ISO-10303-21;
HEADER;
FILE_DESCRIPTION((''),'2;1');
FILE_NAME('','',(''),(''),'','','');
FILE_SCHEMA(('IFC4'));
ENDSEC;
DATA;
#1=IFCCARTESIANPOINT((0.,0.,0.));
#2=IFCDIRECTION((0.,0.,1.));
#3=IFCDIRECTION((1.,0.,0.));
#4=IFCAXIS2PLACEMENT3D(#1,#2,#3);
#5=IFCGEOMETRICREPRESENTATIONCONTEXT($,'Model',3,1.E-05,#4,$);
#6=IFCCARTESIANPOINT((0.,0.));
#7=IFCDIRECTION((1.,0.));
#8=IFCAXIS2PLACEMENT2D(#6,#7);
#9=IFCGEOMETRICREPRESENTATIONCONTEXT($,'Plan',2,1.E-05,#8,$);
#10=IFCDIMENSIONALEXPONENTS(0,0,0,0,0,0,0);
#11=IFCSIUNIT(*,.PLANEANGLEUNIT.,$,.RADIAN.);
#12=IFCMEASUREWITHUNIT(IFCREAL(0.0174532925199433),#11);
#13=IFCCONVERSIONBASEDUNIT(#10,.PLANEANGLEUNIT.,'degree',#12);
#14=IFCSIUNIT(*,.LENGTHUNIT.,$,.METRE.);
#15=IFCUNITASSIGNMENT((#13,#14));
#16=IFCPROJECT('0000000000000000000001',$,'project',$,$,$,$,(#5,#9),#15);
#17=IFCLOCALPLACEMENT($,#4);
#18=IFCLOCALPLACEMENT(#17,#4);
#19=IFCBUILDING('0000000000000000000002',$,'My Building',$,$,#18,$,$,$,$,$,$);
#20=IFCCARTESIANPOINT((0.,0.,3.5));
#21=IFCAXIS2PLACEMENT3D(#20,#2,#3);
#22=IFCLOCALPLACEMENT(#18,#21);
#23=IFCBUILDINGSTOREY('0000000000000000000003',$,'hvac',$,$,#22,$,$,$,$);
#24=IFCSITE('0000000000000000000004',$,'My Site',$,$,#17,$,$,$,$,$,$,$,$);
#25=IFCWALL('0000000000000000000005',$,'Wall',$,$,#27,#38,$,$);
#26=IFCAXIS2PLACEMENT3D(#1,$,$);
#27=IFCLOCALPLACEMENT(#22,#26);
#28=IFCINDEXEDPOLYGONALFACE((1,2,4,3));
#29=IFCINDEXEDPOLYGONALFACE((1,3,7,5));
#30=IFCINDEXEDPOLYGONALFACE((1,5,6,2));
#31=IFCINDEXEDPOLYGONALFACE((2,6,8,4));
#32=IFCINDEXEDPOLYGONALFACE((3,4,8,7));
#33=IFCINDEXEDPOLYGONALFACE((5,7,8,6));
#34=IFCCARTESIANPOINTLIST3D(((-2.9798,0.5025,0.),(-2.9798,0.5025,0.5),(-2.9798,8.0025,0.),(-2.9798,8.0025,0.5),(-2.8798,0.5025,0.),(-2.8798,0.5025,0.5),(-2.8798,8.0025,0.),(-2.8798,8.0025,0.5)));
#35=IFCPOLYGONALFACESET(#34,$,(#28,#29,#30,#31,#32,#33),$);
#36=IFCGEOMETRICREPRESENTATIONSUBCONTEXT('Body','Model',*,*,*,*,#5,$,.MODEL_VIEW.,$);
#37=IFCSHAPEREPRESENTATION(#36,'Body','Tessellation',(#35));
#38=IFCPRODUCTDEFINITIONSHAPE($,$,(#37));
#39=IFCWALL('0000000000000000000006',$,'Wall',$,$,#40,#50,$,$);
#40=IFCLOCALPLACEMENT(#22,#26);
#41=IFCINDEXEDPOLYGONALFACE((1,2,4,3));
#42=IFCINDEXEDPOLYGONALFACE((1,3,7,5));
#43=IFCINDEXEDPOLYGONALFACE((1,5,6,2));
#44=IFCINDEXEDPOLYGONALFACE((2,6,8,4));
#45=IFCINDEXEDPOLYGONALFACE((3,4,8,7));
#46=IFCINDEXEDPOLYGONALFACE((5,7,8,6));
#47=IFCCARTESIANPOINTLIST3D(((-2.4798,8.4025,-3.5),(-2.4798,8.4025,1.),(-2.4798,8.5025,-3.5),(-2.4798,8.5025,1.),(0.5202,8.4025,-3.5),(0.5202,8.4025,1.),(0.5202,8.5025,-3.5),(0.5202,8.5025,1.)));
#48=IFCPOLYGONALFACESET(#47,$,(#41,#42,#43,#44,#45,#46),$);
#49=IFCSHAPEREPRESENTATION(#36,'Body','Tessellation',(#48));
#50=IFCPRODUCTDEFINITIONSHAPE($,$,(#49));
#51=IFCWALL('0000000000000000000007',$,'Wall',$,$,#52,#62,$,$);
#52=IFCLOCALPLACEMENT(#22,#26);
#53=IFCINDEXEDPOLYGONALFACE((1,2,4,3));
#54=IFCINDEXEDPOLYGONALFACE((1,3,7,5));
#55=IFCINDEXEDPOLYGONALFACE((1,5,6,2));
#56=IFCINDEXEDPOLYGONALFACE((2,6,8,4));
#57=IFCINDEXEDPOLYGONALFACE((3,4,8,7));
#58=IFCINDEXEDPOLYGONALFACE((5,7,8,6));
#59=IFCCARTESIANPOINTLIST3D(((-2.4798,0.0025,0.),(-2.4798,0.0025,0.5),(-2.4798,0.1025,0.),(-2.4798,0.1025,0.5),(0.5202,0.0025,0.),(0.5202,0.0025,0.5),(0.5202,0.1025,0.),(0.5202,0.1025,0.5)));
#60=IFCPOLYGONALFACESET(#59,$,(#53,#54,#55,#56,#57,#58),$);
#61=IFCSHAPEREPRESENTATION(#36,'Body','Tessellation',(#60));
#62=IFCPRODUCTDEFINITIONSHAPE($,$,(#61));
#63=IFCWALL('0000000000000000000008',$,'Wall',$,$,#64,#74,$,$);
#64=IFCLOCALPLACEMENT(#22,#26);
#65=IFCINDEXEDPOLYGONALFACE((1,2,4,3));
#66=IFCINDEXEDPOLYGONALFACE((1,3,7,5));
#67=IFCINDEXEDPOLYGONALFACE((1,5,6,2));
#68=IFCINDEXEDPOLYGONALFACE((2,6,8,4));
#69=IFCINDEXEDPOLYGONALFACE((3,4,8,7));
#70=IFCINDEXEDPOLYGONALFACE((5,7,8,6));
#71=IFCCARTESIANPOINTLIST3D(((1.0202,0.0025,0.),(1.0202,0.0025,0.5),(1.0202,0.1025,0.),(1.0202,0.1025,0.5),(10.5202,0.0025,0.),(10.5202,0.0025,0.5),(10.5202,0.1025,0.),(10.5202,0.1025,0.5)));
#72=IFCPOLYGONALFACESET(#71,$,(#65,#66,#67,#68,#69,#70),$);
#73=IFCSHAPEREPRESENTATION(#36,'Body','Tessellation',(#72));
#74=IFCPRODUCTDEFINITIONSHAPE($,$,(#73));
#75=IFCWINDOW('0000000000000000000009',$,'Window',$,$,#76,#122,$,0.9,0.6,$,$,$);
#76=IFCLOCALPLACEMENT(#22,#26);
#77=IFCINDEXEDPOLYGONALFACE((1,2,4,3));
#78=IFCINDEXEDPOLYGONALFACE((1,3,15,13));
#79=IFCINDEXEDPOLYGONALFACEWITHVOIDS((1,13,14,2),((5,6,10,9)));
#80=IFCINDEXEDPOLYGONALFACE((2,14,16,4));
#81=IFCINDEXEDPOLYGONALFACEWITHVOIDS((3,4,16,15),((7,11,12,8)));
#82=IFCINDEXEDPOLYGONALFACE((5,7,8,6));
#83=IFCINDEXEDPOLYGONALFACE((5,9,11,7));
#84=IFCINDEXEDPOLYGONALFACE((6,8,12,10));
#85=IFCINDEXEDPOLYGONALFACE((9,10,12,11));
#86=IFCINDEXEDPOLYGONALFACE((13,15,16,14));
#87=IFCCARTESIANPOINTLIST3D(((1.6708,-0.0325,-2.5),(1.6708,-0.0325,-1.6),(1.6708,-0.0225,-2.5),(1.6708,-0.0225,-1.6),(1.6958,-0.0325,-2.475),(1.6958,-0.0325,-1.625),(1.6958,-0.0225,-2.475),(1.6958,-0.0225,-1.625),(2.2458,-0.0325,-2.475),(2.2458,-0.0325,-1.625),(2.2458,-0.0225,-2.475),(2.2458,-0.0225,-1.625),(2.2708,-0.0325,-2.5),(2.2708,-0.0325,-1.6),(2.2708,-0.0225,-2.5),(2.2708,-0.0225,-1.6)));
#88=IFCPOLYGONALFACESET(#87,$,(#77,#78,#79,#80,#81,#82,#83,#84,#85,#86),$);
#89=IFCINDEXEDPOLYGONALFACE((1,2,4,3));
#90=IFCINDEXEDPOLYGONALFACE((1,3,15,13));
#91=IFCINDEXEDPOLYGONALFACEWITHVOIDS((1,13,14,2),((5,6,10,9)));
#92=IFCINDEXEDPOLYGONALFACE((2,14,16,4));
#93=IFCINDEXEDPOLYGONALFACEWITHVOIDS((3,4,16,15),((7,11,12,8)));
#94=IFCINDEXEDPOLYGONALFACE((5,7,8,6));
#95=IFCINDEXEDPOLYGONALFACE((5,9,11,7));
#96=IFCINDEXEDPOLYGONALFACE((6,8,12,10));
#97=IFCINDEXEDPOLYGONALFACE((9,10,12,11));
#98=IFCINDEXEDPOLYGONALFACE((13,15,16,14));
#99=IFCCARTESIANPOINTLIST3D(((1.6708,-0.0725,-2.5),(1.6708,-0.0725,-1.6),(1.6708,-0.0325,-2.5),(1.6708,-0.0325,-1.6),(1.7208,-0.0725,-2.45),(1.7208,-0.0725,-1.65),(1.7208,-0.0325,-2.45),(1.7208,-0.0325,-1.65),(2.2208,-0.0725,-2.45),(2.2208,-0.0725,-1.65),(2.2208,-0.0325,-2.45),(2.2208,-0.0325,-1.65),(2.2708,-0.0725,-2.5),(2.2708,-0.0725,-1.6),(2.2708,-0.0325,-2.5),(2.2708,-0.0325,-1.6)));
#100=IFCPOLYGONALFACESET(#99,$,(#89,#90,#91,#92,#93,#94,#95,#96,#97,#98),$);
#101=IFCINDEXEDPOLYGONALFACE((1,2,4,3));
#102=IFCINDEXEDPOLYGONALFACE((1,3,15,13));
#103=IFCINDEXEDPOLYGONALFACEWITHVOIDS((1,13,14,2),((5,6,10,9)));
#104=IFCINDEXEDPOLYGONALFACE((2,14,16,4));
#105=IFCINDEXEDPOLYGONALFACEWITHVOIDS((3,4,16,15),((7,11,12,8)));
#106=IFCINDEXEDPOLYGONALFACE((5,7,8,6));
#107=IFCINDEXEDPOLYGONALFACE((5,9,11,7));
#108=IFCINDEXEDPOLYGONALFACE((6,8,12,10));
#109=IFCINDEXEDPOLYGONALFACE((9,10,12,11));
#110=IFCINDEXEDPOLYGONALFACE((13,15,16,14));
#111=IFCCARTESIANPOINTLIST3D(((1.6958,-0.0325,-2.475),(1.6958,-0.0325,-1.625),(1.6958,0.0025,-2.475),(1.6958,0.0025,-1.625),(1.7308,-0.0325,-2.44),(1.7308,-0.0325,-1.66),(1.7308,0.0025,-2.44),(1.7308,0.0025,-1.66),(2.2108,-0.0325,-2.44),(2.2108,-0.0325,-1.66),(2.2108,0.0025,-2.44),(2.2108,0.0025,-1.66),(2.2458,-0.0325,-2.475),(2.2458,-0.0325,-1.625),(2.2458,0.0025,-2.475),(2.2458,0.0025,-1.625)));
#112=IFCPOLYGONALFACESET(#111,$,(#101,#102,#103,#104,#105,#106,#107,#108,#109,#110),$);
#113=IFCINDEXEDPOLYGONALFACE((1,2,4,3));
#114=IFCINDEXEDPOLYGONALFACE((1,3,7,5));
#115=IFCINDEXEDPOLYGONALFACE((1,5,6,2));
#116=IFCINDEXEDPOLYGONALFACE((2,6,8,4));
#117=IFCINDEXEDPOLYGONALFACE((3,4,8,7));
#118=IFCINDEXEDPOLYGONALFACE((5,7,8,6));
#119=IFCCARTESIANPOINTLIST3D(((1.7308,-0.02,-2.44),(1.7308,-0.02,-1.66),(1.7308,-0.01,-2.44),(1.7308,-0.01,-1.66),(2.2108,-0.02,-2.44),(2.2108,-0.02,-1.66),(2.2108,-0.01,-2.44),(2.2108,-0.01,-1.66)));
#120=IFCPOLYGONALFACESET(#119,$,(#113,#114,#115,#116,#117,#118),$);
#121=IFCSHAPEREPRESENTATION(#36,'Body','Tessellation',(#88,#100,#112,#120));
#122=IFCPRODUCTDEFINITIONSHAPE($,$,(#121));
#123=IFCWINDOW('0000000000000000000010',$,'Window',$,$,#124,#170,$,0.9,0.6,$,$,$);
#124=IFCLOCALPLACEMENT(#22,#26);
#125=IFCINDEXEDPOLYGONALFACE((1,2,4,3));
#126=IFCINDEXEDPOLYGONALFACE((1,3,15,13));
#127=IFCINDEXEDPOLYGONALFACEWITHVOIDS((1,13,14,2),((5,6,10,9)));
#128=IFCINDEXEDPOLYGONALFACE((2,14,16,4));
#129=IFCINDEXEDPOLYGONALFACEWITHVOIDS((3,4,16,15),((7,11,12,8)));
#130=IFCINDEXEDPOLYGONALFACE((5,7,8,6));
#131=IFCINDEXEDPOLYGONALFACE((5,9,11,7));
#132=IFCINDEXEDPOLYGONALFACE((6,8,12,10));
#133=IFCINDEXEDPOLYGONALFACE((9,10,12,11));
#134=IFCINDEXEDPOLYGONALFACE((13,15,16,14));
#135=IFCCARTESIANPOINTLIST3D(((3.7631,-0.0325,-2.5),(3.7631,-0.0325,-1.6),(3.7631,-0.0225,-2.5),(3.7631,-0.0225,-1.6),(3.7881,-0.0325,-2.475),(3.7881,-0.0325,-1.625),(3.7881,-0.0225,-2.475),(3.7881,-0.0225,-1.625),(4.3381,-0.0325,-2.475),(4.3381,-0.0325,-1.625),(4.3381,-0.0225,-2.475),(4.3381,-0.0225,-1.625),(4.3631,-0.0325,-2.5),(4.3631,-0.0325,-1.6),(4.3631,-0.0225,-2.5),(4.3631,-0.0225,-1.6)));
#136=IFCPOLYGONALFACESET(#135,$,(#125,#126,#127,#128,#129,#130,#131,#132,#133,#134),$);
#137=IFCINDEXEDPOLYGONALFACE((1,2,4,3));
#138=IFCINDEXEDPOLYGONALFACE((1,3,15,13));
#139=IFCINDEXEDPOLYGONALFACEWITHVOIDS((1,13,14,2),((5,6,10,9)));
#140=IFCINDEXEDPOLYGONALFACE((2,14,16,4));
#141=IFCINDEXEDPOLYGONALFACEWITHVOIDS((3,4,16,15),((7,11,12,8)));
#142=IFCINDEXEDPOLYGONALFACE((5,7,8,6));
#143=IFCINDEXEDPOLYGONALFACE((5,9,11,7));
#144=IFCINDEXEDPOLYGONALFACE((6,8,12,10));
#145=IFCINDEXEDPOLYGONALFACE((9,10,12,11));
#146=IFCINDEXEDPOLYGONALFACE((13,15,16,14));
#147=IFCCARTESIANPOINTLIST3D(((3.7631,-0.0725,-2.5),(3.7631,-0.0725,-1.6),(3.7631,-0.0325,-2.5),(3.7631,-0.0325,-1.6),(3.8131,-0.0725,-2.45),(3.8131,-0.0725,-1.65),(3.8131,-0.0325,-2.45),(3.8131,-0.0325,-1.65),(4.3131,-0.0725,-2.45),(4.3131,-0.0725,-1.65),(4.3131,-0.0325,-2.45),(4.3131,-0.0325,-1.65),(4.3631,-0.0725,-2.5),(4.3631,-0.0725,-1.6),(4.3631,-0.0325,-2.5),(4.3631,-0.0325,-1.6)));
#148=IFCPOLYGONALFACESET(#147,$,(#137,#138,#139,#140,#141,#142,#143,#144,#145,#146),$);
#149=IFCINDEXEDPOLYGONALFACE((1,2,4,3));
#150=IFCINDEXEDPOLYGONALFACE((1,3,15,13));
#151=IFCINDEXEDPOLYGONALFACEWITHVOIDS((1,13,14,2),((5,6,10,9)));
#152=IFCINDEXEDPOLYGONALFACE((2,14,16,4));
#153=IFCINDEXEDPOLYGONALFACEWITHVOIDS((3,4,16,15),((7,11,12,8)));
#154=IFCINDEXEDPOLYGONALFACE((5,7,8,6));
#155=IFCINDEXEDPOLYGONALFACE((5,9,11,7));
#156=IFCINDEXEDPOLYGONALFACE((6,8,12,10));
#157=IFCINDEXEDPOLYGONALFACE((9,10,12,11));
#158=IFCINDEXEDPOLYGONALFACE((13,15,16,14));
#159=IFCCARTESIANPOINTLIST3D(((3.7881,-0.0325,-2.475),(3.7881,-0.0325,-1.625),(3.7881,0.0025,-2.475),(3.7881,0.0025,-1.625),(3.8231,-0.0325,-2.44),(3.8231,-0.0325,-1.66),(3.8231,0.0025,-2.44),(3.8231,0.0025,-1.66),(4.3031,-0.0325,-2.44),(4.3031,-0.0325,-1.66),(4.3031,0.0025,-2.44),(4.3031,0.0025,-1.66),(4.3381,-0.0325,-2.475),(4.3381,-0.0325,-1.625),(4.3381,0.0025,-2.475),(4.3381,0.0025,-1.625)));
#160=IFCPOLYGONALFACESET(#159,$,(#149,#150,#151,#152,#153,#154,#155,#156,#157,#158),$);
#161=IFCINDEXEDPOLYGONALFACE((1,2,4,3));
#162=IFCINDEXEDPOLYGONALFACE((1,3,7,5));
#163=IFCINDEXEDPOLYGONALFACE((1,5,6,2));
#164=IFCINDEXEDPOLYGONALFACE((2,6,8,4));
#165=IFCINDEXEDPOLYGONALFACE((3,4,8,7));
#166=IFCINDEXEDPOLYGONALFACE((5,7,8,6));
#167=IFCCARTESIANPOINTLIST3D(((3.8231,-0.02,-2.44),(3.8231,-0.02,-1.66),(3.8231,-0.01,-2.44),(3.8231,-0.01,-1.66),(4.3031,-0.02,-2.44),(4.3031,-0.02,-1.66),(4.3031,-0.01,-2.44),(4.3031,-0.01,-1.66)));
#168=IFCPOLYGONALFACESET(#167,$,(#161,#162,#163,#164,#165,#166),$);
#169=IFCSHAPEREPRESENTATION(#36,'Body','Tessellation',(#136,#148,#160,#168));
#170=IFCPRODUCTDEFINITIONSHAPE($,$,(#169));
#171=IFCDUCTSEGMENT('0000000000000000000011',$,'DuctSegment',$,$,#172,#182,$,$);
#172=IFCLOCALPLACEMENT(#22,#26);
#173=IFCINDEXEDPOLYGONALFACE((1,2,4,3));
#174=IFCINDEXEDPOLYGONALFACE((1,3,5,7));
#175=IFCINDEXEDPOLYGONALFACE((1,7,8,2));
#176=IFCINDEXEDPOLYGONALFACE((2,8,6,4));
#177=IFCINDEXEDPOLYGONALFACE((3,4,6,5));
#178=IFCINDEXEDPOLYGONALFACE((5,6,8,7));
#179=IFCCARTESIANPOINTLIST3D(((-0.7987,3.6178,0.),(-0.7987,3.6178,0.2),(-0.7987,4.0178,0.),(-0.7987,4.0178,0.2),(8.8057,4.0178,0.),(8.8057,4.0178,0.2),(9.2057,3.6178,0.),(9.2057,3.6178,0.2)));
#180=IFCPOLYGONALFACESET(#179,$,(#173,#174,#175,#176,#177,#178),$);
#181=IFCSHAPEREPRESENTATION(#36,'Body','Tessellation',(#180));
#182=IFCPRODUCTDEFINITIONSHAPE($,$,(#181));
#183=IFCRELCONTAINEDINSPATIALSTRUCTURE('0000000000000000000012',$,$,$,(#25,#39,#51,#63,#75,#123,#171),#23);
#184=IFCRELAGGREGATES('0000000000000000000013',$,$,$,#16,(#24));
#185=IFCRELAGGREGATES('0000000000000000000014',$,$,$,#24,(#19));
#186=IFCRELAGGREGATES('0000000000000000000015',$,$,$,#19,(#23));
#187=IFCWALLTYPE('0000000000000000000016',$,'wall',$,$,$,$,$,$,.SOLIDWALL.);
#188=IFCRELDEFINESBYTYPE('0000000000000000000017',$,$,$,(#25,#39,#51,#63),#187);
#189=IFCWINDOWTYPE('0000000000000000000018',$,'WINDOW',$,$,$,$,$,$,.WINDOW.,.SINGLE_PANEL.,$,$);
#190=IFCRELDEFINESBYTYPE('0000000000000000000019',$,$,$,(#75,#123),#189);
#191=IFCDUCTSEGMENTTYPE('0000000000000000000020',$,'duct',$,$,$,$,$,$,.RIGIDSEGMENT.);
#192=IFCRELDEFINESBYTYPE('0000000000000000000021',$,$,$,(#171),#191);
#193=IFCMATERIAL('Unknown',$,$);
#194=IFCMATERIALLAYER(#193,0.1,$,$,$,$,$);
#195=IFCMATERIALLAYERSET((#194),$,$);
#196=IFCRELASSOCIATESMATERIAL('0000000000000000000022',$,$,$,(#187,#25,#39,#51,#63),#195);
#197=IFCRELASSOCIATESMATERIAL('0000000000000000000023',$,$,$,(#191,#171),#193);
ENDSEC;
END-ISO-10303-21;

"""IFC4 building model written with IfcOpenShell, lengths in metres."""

from ifc_helpers import new_model, entity, si_unit, converted_unit, frame, origin_with_axes, origin_2d_with_axis, place, context, subcontext, project, spatial, line, indexed_curve, rectangle, outline, extrude, clip, halfspace, shape, source, transform, mapped, material, layer, layer_set, layer_usage, material_profile, profile_set, profile_usage, type_object, type_shapes, element, save


model = new_model("IFC4")

# Units and contexts
model_context = context("Model", 3, precision=1e-05, world=origin_with_axes())
plan_context = context("Plan", 2, precision=1e-05, world=origin_2d_with_axis())
body_context_1 = subcontext(model_context, "Body", "Model", "MODEL_VIEW")
body_context_2 = subcontext(plan_context, "Body", "Plan", "PLAN_VIEW")
ifc_project = project(units=[converted_unit("PLANEANGLEUNIT", "degree", entity("IfcReal", 0.0174532925199433), si_unit("PLANEANGLEUNIT", "RADIAN"), dimensions=[0, 0, 0, 0, 0, 0, 0]), si_unit("LENGTHUNIT", "METRE")], contexts=[model_context, plan_context])

# Site, building, storey
site_placement = place(None, origin_with_axes())
site = spatial("IfcSite", under=ifc_project, at=site_placement, Name="My Site")
building_placement = place(site_placement, origin_with_axes())
building = spatial("IfcBuilding", under=site, at=building_placement, Name="My Building")
storey_placement = place(building_placement, frame((0.0, 0.0, 3.5), z_axis=(0.0, 0.0, 1.0), x_axis=(1.0, 0.0, 0.0)))
storey = spatial("IfcBuildingStorey", under=building, at=storey_placement, Name="hvac")

# Walls
ifc_material = material(Name="Unknown")
ifc_layer = layer(ifc_material, 0.1)
ifc_layer_set = layer_set([ifc_layer])
ifc_layer_usage_1 = layer_usage(ifc_layer_set, "AXIS2", "POSITIVE", 0.0)
wall_type = type_object("IfcWallType", Name="wall", PredefinedType="SOLIDWALL", material=ifc_layer_set)
wall_1_placement = place(storey_placement, frame((-2.9798, 8.0025, 0.0), z_axis=(0.0, 0.0, 1.0), x_axis=(0.0, -1.0, 0.0)))
element("IfcWall", 1, at=wall_1_placement, inside=storey, type_object=wall_type, material=ifc_layer_usage_1, Name="Wall", context=body_context_1, shape_type="SweptSolid", body=[
    extrude(outline(indexed_curve([(0.0, 0.0), (0.0, 0.1), (7.5, 0.1), (7.5, 0.0)], segments=[line(1, 2, 3, 4, 1)])), origin_with_axes(), (0.0, 0.0, 1.0), 0.5),
])
ifc_layer_usage_2 = layer_usage(ifc_layer_set, "AXIS2", "POSITIVE", 0.0)
wall_2_placement = place(storey_placement, frame((-2.4798, 8.4025, -3.5), z_axis=(0.0, 0.0, 1.0), x_axis=(1.0, 0.0, 0.0)))
element("IfcWall", 2, at=wall_2_placement, inside=storey, type_object=wall_type, material=ifc_layer_usage_2, Name="Wall", context=body_context_1, shape_type="SweptSolid", body=[
    extrude(outline(indexed_curve([(0.0, 0.0), (0.0, 0.1), (3.0, 0.1), (3.0, 0.0)], segments=[line(1, 2, 3, 4, 1)])), origin_with_axes(), (0.0, 0.0, 1.0), 4.5),
])

# Shared definitions
window_type = type_object("IfcWindowType", Name="WINDOW", PartitioningType="SINGLE_PANEL", PredefinedType="WINDOW")
shared_shape_1 = source(origin_with_axes(), body_context_1, "Body", "SweptSolid", [
    extrude(outline(indexed_curve([(0.0, 0.0), (0.6, 0.0), (0.6, 0.9), (0.0, 0.9)], segments=[line(1, 2, 3, 4, 1)]), holes=[indexed_curve([(0.025, 0.025), (0.575, 0.025), (0.575, 0.875), (0.025, 0.875)], segments=[line(1, 2, 3, 4, 1)])]), frame((0.0, 0.09, 0.0), z_axis=(0.0, -1.0, 0.0), x_axis=(1.0, 0.0, 0.0)), (0.0, 0.0, -1.0), 0.01),
    extrude(outline(indexed_curve([(0.0, 0.0), (0.6, 0.0), (0.6, 0.9), (0.0, 0.9)], segments=[line(1, 2, 3, 4, 1)]), holes=[indexed_curve([(0.05, 0.05), (0.55, 0.05), (0.55, 0.85), (0.05, 0.85)], segments=[line(1, 2, 3, 4, 1)])]), frame((0.0, 0.05, 0.0), z_axis=(0.0, -1.0, 0.0), x_axis=(1.0, 0.0, 0.0)), (0.0, 0.0, -1.0), 0.04),
    extrude(outline(indexed_curve([(0.0, 0.0), (0.55, 0.0), (0.55, 0.85), (0.0, 0.85)], segments=[line(1, 2, 3, 4, 1)]), holes=[indexed_curve([(0.035, 0.035), (0.515, 0.035), (0.515, 0.815), (0.035, 0.815)], segments=[line(1, 2, 3, 4, 1)])]), frame((0.025, 0.09, 0.025), z_axis=(0.0, -1.0, 0.0), x_axis=(1.0, 0.0, 0.0)), (0.0, 0.0, -1.0), 0.035),
    extrude(outline(indexed_curve([(0.035, 0.035), (0.515, 0.035), (0.515, 0.815), (0.035, 0.815)], segments=[line(1, 2, 3, 4, 1)])), frame((0.025, 0.1025, 0.025), z_axis=(0.0, -1.0, 0.0), x_axis=(1.0, 0.0, 0.0)), (0.0, 0.0, -1.0), 0.01),
])
shared_shape_2 = source(origin_with_axes(), body_context_2, "Body", "Curve2D", [
    entity("IfcIndexedPolyCurve", entity("IfcCartesianPointList2D", [[0.05, 0.05], [0.55, 0.05]])),
    entity("IfcIndexedPolyCurve", entity("IfcCartesianPointList2D", [[0.0, 0.1], [0.025, 0.1], [0.025, 0.09], [0.05, 0.09], [0.05, 0.05], [0.0, 0.05]]), [entity("IfcLineIndex", [1, 2, 3, 4, 5, 6, 1])]),
    entity("IfcIndexedPolyCurve", entity("IfcCartesianPointList2D", [[0.6, 0.1], [0.575, 0.1], [0.575, 0.09], [0.55, 0.09], [0.55, 0.05], [0.6, 0.05]]), [entity("IfcLineIndex", [1, 2, 3, 4, 5, 6, 1])]),
    entity("IfcIndexedPolyCurve", entity("IfcCartesianPointList2D", [[0.025, 0.09], [0.06, 0.09], [0.06, 0.125], [0.025, 0.125]]), [entity("IfcLineIndex", [1, 2, 3, 4, 1])]),
    entity("IfcIndexedPolyCurve", entity("IfcCartesianPointList2D", [[0.575, 0.09], [0.54, 0.09], [0.54, 0.125], [0.575, 0.125]]), [entity("IfcLineIndex", [1, 2, 3, 4, 1])]),
    entity("IfcIndexedPolyCurve", entity("IfcCartesianPointList2D", [[0.06, 0.09], [0.54, 0.09]])),
    entity("IfcIndexedPolyCurve", entity("IfcCartesianPointList2D", [[0.06, 0.125], [0.54, 0.125]])),
    entity("IfcIndexedPolyCurve", entity("IfcCartesianPointList2D", [[0.06, 0.1075], [0.54, 0.1075]])),
])
type_shapes(window_type, [shared_shape_1, shared_shape_2])

# Walls
ifc_layer_usage_3 = layer_usage(ifc_layer_set, "AXIS2", "POSITIVE", 0.0)
wall_3_placement = place(storey_placement, frame((-2.4798, 0.0025, 0.0), z_axis=(0.0, 0.0, 1.0), x_axis=(1.0, 0.0, 0.0)))
element("IfcWall", 3, at=wall_3_placement, inside=storey, type_object=wall_type, material=ifc_layer_usage_3, Name="Wall", context=body_context_1, shape_type="SweptSolid", body=[
    extrude(outline(indexed_curve([(0.0, 0.0), (0.0, 0.1), (3.0, 0.1), (3.0, 0.0)], segments=[line(1, 2, 3, 4, 1)])), origin_with_axes(), (0.0, 0.0, 1.0), 0.5),
])
ifc_layer_usage_4 = layer_usage(ifc_layer_set, "AXIS2", "POSITIVE", 0.0)
wall_4_placement = place(storey_placement, frame((1.0202, 0.0025, 0.0), z_axis=(0.0, 0.0, 1.0), x_axis=(1.0, 0.0, 0.0)))
element("IfcWall", 4, at=wall_4_placement, inside=storey, type_object=wall_type, material=ifc_layer_usage_4, Name="Wall", context=body_context_1, shape_type="SweptSolid", body=[
    extrude(outline(indexed_curve([(0.0, 0.0), (0.0, 0.1), (9.5, 0.1), (9.5, 0.0)], segments=[line(1, 2, 3, 4, 1)])), origin_with_axes(), (0.0, 0.0, 1.0), 0.5),
])

# Windows
for number, where, z_axis, x_axis, name in (
    (5, (1.6708, -0.1225, -2.5), (0.0, 0.0, 1.0), (1.0, 0.0, 0.0), "Window"),
    (6, (3.7631, -0.1225, -2.5), (0.0, 0.0, 1.0), (1.0, 0.0, 0.0), "Window"),
):
    element("IfcWindow", number, at=place(storey_placement, frame(where, z_axis=z_axis, x_axis=x_axis)), inside=storey, type_object=window_type, Name=name, OverallHeight=0.9, OverallWidth=0.6, shapes=[
        shape(body_context_1, "Body", "MappedRepresentation", [mapped(shared_shape_1, transform((0.0, 0.0, 0.0), x_axis=(1.0, 0.0, 0.0), y_axis=(0.0, 1.0, 0.0), z_axis=(0.0, 0.0, 1.0), scale=1.0))]),
        shape(body_context_2, "Body", "MappedRepresentation", [mapped(shared_shape_2, transform((0.0, 0.0, 0.0), x_axis=(1.0, 0.0, 0.0), y_axis=(0.0, 1.0, 0.0), z_axis=(0.0, 0.0, 1.0), scale=1.0))]),
    ])

# Duct segment
ifc_material_profile_1 = material_profile(ifc_material, rectangle(XDim=0.4, YDim=0.2))
ifc_profile_set_1 = profile_set([ifc_material_profile_1])
ifc_profile_usage_1 = profile_usage(ifc_profile_set_1, cardinal=5)
duct_segment_type = type_object("IfcDuctSegmentType", Name="duct", PredefinedType="RIGIDSEGMENT", material=ifc_profile_set_1)
duct_segment_1_placement = place(storey_placement, frame((-0.7987, 3.8178, 0.1), z_axis=(1.0, 0.0, 0.0), x_axis=(0.0, 1.0, 0.0)))
element("IfcDuctSegment", 7, at=duct_segment_1_placement, inside=storey, type_object=duct_segment_type, material=ifc_profile_usage_1, Name="DuctSegment", context=body_context_1, shape_type="Clipping", body=[
    clip(extrude(rectangle(XDim=0.4, YDim=0.2), origin_with_axes(), (0.0, 0.0, 1.0), 10.0044), halfspace(frame((-0.2, -3.6, 10.0044), z_axis=(0.707107, 0.0, 0.707106), x_axis=(-0.000001, -1.0, 0.0)), False)),
])

save(model, "model.ifc")
